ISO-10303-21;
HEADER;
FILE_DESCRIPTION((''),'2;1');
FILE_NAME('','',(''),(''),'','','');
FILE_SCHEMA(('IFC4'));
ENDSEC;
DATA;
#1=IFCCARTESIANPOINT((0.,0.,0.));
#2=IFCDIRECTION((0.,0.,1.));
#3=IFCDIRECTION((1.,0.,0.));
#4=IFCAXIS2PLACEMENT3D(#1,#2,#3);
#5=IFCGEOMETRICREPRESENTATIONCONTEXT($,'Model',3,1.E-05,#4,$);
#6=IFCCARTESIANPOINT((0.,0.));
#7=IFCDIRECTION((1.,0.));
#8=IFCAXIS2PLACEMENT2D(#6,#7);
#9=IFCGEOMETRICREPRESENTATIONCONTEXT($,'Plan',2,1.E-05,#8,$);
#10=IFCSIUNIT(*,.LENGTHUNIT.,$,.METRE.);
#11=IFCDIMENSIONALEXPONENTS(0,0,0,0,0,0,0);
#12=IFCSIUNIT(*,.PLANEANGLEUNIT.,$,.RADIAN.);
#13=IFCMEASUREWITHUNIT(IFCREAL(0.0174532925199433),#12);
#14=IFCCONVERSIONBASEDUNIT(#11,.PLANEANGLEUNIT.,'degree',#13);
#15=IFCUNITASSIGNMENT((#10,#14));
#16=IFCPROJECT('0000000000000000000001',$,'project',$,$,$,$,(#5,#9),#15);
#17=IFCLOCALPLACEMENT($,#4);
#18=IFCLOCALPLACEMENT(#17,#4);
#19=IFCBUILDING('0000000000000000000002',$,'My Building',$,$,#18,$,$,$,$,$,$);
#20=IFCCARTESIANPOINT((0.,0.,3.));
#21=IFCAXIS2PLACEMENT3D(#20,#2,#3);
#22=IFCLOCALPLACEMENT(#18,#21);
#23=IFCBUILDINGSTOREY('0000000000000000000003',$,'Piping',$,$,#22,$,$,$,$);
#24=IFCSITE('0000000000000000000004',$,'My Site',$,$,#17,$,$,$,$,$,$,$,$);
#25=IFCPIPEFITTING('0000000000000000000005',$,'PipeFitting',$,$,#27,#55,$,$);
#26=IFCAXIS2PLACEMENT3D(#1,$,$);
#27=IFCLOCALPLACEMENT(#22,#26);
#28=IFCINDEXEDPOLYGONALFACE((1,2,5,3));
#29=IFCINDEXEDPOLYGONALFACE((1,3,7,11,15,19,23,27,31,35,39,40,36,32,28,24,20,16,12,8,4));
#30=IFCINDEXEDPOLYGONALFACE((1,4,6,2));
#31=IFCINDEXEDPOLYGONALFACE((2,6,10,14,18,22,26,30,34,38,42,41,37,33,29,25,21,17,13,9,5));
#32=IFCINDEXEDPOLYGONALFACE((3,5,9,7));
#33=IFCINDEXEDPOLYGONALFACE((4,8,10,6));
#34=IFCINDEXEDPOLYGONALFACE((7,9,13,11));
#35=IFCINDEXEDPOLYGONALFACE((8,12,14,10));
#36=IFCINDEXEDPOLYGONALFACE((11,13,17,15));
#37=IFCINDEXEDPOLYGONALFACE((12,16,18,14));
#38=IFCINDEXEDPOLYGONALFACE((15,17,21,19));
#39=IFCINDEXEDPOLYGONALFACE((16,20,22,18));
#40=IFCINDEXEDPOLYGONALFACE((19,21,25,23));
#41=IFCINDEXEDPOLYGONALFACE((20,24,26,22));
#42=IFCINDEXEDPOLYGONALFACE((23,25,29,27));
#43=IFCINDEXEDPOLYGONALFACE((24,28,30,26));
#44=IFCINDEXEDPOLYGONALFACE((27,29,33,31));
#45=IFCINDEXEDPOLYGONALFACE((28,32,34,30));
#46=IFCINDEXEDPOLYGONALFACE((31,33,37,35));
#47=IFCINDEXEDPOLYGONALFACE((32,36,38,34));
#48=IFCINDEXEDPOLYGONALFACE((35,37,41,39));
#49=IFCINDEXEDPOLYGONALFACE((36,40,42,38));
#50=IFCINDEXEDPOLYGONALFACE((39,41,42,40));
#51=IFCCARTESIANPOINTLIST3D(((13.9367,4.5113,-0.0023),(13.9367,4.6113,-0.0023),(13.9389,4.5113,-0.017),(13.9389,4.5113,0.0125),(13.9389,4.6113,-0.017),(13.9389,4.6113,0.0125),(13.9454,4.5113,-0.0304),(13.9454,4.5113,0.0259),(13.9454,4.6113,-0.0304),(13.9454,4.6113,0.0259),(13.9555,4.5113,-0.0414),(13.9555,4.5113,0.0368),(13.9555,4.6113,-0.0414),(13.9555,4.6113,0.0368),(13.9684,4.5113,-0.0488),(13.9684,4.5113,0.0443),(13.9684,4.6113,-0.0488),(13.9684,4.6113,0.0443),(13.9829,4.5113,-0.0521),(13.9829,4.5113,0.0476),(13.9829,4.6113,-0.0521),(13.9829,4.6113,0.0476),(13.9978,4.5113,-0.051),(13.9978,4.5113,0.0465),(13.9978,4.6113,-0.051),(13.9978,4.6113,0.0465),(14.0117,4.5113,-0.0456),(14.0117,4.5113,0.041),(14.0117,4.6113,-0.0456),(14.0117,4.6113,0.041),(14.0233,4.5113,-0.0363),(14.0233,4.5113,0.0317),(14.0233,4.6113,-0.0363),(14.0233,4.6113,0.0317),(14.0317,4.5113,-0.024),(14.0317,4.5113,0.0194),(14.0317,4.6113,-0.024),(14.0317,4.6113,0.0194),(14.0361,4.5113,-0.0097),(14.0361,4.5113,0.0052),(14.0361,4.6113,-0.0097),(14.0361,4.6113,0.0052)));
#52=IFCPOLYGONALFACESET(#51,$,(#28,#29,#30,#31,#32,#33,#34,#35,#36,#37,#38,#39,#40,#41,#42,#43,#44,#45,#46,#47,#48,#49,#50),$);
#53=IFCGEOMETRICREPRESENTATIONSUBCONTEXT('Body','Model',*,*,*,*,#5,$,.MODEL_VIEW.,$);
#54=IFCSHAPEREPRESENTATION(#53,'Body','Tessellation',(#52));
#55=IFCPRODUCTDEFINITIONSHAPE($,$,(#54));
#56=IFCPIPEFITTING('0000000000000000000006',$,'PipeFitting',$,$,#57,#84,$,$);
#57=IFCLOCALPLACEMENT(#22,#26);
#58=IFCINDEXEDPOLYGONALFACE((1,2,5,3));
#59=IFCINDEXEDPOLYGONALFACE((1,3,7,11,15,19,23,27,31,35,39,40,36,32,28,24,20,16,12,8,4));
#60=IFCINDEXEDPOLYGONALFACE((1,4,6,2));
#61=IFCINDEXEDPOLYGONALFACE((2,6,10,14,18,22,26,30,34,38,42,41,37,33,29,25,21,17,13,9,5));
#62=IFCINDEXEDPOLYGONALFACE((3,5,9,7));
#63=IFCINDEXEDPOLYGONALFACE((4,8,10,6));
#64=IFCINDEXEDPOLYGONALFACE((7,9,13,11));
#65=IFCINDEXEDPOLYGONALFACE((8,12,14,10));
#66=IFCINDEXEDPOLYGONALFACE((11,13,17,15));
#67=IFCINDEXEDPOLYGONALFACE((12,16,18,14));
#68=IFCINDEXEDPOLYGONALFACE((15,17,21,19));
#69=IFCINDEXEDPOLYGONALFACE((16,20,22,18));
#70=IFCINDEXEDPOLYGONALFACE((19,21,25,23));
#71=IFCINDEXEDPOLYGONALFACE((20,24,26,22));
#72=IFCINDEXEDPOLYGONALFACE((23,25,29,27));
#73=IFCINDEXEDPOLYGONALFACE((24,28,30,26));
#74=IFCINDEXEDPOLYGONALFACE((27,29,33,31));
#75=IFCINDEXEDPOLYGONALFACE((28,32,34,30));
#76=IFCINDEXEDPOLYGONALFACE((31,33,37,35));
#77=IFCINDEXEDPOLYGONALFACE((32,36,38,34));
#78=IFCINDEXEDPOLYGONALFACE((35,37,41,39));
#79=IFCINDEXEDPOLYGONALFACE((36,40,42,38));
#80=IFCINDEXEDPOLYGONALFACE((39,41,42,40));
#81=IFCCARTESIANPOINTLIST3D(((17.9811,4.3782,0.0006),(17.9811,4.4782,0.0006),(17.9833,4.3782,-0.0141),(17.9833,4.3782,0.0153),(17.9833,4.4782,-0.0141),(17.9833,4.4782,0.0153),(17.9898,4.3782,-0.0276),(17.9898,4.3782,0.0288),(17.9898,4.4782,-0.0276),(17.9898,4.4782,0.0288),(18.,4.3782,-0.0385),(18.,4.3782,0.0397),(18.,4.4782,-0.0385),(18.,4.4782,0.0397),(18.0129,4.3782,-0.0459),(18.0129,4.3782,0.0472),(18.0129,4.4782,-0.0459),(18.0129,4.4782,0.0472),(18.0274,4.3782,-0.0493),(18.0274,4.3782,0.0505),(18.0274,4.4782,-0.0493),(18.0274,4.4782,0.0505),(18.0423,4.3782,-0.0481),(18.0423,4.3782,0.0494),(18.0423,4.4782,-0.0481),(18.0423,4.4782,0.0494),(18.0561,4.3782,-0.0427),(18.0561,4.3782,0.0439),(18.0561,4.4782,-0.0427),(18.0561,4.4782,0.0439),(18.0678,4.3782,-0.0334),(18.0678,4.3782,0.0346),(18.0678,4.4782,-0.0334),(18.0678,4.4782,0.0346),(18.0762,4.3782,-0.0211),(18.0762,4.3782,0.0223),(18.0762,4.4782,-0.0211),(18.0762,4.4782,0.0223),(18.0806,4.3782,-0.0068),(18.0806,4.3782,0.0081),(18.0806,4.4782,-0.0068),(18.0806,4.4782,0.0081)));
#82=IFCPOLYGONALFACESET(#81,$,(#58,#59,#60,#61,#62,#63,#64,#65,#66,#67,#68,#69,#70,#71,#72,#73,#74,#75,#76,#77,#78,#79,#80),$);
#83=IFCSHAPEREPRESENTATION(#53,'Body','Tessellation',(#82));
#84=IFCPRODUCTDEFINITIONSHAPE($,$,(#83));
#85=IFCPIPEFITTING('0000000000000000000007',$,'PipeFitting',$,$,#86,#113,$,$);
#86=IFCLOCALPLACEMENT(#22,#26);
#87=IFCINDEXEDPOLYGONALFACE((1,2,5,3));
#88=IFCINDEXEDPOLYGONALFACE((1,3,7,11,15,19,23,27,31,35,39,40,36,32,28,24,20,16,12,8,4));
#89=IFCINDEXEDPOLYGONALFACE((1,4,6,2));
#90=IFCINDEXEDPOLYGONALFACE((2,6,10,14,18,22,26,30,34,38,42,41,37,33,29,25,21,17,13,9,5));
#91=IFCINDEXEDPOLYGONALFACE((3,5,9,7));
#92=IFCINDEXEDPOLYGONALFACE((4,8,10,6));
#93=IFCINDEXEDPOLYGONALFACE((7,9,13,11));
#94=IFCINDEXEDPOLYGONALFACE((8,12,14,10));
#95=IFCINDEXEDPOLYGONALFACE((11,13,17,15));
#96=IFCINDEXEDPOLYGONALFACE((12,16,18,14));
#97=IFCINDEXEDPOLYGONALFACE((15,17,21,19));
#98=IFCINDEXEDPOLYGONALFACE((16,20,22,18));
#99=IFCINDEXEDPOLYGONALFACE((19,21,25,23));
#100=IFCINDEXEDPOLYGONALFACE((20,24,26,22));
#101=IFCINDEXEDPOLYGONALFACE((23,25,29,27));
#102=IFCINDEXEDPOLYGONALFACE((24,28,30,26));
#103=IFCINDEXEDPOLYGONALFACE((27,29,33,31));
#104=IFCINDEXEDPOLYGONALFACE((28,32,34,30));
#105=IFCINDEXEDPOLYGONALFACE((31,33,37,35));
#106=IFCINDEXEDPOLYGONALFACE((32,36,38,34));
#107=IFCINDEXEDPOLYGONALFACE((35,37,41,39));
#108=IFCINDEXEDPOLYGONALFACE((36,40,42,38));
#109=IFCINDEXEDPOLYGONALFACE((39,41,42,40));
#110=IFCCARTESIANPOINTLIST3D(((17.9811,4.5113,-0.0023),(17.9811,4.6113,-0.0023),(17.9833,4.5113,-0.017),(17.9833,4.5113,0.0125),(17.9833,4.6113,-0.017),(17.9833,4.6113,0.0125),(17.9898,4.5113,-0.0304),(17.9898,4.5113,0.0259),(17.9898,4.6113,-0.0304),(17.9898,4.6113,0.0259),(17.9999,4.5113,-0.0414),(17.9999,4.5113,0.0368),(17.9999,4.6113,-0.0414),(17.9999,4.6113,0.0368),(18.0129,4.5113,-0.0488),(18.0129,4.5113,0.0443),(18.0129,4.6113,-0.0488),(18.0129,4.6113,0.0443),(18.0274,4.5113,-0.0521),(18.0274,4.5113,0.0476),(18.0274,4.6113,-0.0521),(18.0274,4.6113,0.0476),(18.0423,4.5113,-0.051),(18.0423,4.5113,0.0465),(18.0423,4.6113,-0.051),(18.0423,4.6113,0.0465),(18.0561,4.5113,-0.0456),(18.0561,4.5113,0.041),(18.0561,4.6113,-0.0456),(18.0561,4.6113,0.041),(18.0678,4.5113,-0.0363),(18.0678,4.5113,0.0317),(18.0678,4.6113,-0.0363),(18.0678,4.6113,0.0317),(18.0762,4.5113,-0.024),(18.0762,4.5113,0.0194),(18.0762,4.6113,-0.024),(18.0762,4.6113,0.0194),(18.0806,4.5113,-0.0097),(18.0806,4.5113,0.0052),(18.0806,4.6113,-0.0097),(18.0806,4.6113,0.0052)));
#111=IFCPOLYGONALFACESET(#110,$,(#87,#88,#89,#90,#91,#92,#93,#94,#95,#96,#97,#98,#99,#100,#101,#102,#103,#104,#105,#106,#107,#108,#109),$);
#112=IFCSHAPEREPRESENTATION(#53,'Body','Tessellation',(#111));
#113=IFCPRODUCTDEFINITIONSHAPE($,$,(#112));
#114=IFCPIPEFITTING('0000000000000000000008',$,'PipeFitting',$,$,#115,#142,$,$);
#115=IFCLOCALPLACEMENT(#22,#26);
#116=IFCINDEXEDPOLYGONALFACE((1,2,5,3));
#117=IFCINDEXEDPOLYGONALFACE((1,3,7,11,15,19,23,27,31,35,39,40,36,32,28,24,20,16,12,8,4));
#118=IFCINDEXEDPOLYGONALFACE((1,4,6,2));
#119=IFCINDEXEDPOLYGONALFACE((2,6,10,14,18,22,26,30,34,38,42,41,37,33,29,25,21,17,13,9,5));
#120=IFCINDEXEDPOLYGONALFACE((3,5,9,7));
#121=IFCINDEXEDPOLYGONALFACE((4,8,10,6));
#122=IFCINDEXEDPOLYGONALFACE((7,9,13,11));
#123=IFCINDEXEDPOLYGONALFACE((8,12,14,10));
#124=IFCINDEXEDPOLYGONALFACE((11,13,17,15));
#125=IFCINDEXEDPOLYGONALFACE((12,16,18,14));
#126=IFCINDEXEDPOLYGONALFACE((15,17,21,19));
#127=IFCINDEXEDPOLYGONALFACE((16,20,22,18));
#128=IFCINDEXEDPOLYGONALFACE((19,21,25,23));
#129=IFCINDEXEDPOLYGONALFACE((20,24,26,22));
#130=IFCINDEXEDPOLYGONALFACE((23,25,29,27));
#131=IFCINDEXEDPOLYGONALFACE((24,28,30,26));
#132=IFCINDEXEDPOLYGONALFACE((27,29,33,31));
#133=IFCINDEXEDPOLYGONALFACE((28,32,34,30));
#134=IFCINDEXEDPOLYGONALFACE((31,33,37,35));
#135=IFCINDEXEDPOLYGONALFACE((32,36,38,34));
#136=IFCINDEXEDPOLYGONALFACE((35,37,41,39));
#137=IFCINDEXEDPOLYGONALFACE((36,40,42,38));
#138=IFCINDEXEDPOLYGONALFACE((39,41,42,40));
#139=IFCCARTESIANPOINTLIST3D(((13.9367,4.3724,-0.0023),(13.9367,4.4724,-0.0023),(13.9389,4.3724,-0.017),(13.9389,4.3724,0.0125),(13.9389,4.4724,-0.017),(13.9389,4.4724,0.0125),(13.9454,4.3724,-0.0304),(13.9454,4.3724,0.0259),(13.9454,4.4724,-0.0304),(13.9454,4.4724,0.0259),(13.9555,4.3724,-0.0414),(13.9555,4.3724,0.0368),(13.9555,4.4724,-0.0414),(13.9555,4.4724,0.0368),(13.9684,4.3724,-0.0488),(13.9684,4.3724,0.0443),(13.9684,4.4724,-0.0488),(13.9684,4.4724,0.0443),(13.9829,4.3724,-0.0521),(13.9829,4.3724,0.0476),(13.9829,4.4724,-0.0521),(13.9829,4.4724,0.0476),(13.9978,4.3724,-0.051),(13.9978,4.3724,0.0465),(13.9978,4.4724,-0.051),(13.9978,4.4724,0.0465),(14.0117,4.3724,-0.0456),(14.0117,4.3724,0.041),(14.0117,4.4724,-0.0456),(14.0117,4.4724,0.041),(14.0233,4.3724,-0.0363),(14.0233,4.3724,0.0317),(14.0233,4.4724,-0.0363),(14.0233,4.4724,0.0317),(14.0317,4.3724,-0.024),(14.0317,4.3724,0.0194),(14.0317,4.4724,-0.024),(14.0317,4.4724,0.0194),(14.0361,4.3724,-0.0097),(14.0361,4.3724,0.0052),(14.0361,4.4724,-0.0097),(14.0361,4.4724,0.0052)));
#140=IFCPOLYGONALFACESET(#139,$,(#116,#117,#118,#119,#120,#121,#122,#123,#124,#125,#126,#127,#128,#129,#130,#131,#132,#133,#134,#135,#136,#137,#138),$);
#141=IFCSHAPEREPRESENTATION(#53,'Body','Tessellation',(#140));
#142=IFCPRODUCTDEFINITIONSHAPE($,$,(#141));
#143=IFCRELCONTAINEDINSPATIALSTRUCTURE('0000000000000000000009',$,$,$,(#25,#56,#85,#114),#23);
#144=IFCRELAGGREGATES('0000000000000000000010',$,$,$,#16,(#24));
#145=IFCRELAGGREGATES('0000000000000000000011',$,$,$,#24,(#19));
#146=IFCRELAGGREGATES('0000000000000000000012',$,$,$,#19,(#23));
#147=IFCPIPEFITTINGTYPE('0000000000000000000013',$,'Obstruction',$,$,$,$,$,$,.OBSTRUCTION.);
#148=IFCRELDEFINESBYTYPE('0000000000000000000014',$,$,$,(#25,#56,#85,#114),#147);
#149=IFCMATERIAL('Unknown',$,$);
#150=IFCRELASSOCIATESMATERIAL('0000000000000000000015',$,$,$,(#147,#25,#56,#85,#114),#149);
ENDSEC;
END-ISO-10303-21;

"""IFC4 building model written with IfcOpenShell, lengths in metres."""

from ifc_helpers import new_model, entity, si_unit, converted_unit, frame, origin_with_axes, origin_2d_with_axis, place, context, subcontext, project, spatial, circle, extrude, material, material_profile, profile_set, profile_usage, type_object, element, save


model = new_model("IFC4")

# Units and contexts
model_context = context("Model", 3, precision=1e-05, world=origin_with_axes())
plan_context = context("Plan", 2, precision=1e-05, world=origin_2d_with_axis())
body_context = subcontext(model_context, "Body", "Model", "MODEL_VIEW")
ifc_project = project(units=[si_unit("LENGTHUNIT", "METRE"), converted_unit("PLANEANGLEUNIT", "degree", entity("IfcReal", 0.0174532925199433), si_unit("PLANEANGLEUNIT", "RADIAN"), dimensions=[0, 0, 0, 0, 0, 0, 0])], contexts=[model_context, plan_context])

# Site, building, storey
site_placement = place(None, origin_with_axes())
site = spatial("IfcSite", under=ifc_project, at=site_placement, Name="My Site")
building_placement = place(site_placement, origin_with_axes())
building = spatial("IfcBuilding", under=site, at=building_placement, Name="My Building")
storey_placement = place(building_placement, frame((0.0, 0.0, 3.0), z_axis=(0.0, 0.0, 1.0), x_axis=(1.0, 0.0, 0.0)))
storey = spatial("IfcBuildingStorey", under=building, at=storey_placement, Name="Piping")

# Shared definitions
ifc_material = material(Name="Unknown")

# Pipe fittings
ifc_material_profile_1 = material_profile(ifc_material, circle(Radius=0.05))
ifc_profile_set_1 = profile_set([ifc_material_profile_1])
ifc_profile_usage_1 = profile_usage(ifc_profile_set_1, cardinal=5)
pipe_fitting_type_1 = type_object("IfcPipeFittingType", Name="Obstruction", PredefinedType="OBSTRUCTION", material=ifc_profile_set_1)
pipe_fitting_1_placement = place(storey_placement, frame((13.9867, 4.5113, -0.0023), z_axis=(0.0, 1.0, 0.0), x_axis=(-1.0, 0.0, 0.0)))
element("IfcPipeFitting", 1, at=pipe_fitting_1_placement, inside=storey, type_object=pipe_fitting_type_1, material=ifc_profile_usage_1, Name="PipeFitting", context=body_context, shape_type="SweptSolid", body=[
    extrude(circle(Radius=0.05), origin_with_axes(), (0.0, 0.0, 1.0), 0.1),
])
ifc_profile_usage_2 = profile_usage(ifc_profile_set_1, cardinal=5)
pipe_fitting_2_placement = place(storey_placement, frame((18.0311, 4.3782, 0.0006), z_axis=(0.0, 1.0, 0.0), x_axis=(-1.0, 0.0, 0.0)))
element("IfcPipeFitting", 2, at=pipe_fitting_2_placement, inside=storey, type_object=pipe_fitting_type_1, material=ifc_profile_usage_2, Name="PipeFitting", context=body_context, shape_type="SweptSolid", body=[
    extrude(circle(Radius=0.05), origin_with_axes(), (0.0, 0.0, 1.0), 0.1),
])
ifc_profile_usage_3 = profile_usage(ifc_profile_set_1, cardinal=5)
pipe_fitting_3_placement = place(storey_placement, frame((18.0311, 4.5113, -0.0023), z_axis=(0.0, 1.0, 0.0), x_axis=(-1.0, 0.0, 0.0)))
element("IfcPipeFitting", 3, at=pipe_fitting_3_placement, inside=storey, type_object=pipe_fitting_type_1, material=ifc_profile_usage_3, Name="PipeFitting", context=body_context, shape_type="SweptSolid", body=[
    extrude(circle(Radius=0.05), origin_with_axes(), (0.0, 0.0, 1.0), 0.1),
])
ifc_profile_usage_4 = profile_usage(ifc_profile_set_1, cardinal=5)
pipe_fitting_4_placement = place(storey_placement, frame((13.9867, 4.3724, -0.0023), z_axis=(0.0, 1.0, 0.0), x_axis=(-1.0, 0.0, 0.0)))
element("IfcPipeFitting", 4, at=pipe_fitting_4_placement, inside=storey, type_object=pipe_fitting_type_1, material=ifc_profile_usage_4, Name="PipeFitting", context=body_context, shape_type="SweptSolid", body=[
    extrude(circle(Radius=0.05), origin_with_axes(), (0.0, 0.0, 1.0), 0.1),
])

save(model, "model.ifc")
